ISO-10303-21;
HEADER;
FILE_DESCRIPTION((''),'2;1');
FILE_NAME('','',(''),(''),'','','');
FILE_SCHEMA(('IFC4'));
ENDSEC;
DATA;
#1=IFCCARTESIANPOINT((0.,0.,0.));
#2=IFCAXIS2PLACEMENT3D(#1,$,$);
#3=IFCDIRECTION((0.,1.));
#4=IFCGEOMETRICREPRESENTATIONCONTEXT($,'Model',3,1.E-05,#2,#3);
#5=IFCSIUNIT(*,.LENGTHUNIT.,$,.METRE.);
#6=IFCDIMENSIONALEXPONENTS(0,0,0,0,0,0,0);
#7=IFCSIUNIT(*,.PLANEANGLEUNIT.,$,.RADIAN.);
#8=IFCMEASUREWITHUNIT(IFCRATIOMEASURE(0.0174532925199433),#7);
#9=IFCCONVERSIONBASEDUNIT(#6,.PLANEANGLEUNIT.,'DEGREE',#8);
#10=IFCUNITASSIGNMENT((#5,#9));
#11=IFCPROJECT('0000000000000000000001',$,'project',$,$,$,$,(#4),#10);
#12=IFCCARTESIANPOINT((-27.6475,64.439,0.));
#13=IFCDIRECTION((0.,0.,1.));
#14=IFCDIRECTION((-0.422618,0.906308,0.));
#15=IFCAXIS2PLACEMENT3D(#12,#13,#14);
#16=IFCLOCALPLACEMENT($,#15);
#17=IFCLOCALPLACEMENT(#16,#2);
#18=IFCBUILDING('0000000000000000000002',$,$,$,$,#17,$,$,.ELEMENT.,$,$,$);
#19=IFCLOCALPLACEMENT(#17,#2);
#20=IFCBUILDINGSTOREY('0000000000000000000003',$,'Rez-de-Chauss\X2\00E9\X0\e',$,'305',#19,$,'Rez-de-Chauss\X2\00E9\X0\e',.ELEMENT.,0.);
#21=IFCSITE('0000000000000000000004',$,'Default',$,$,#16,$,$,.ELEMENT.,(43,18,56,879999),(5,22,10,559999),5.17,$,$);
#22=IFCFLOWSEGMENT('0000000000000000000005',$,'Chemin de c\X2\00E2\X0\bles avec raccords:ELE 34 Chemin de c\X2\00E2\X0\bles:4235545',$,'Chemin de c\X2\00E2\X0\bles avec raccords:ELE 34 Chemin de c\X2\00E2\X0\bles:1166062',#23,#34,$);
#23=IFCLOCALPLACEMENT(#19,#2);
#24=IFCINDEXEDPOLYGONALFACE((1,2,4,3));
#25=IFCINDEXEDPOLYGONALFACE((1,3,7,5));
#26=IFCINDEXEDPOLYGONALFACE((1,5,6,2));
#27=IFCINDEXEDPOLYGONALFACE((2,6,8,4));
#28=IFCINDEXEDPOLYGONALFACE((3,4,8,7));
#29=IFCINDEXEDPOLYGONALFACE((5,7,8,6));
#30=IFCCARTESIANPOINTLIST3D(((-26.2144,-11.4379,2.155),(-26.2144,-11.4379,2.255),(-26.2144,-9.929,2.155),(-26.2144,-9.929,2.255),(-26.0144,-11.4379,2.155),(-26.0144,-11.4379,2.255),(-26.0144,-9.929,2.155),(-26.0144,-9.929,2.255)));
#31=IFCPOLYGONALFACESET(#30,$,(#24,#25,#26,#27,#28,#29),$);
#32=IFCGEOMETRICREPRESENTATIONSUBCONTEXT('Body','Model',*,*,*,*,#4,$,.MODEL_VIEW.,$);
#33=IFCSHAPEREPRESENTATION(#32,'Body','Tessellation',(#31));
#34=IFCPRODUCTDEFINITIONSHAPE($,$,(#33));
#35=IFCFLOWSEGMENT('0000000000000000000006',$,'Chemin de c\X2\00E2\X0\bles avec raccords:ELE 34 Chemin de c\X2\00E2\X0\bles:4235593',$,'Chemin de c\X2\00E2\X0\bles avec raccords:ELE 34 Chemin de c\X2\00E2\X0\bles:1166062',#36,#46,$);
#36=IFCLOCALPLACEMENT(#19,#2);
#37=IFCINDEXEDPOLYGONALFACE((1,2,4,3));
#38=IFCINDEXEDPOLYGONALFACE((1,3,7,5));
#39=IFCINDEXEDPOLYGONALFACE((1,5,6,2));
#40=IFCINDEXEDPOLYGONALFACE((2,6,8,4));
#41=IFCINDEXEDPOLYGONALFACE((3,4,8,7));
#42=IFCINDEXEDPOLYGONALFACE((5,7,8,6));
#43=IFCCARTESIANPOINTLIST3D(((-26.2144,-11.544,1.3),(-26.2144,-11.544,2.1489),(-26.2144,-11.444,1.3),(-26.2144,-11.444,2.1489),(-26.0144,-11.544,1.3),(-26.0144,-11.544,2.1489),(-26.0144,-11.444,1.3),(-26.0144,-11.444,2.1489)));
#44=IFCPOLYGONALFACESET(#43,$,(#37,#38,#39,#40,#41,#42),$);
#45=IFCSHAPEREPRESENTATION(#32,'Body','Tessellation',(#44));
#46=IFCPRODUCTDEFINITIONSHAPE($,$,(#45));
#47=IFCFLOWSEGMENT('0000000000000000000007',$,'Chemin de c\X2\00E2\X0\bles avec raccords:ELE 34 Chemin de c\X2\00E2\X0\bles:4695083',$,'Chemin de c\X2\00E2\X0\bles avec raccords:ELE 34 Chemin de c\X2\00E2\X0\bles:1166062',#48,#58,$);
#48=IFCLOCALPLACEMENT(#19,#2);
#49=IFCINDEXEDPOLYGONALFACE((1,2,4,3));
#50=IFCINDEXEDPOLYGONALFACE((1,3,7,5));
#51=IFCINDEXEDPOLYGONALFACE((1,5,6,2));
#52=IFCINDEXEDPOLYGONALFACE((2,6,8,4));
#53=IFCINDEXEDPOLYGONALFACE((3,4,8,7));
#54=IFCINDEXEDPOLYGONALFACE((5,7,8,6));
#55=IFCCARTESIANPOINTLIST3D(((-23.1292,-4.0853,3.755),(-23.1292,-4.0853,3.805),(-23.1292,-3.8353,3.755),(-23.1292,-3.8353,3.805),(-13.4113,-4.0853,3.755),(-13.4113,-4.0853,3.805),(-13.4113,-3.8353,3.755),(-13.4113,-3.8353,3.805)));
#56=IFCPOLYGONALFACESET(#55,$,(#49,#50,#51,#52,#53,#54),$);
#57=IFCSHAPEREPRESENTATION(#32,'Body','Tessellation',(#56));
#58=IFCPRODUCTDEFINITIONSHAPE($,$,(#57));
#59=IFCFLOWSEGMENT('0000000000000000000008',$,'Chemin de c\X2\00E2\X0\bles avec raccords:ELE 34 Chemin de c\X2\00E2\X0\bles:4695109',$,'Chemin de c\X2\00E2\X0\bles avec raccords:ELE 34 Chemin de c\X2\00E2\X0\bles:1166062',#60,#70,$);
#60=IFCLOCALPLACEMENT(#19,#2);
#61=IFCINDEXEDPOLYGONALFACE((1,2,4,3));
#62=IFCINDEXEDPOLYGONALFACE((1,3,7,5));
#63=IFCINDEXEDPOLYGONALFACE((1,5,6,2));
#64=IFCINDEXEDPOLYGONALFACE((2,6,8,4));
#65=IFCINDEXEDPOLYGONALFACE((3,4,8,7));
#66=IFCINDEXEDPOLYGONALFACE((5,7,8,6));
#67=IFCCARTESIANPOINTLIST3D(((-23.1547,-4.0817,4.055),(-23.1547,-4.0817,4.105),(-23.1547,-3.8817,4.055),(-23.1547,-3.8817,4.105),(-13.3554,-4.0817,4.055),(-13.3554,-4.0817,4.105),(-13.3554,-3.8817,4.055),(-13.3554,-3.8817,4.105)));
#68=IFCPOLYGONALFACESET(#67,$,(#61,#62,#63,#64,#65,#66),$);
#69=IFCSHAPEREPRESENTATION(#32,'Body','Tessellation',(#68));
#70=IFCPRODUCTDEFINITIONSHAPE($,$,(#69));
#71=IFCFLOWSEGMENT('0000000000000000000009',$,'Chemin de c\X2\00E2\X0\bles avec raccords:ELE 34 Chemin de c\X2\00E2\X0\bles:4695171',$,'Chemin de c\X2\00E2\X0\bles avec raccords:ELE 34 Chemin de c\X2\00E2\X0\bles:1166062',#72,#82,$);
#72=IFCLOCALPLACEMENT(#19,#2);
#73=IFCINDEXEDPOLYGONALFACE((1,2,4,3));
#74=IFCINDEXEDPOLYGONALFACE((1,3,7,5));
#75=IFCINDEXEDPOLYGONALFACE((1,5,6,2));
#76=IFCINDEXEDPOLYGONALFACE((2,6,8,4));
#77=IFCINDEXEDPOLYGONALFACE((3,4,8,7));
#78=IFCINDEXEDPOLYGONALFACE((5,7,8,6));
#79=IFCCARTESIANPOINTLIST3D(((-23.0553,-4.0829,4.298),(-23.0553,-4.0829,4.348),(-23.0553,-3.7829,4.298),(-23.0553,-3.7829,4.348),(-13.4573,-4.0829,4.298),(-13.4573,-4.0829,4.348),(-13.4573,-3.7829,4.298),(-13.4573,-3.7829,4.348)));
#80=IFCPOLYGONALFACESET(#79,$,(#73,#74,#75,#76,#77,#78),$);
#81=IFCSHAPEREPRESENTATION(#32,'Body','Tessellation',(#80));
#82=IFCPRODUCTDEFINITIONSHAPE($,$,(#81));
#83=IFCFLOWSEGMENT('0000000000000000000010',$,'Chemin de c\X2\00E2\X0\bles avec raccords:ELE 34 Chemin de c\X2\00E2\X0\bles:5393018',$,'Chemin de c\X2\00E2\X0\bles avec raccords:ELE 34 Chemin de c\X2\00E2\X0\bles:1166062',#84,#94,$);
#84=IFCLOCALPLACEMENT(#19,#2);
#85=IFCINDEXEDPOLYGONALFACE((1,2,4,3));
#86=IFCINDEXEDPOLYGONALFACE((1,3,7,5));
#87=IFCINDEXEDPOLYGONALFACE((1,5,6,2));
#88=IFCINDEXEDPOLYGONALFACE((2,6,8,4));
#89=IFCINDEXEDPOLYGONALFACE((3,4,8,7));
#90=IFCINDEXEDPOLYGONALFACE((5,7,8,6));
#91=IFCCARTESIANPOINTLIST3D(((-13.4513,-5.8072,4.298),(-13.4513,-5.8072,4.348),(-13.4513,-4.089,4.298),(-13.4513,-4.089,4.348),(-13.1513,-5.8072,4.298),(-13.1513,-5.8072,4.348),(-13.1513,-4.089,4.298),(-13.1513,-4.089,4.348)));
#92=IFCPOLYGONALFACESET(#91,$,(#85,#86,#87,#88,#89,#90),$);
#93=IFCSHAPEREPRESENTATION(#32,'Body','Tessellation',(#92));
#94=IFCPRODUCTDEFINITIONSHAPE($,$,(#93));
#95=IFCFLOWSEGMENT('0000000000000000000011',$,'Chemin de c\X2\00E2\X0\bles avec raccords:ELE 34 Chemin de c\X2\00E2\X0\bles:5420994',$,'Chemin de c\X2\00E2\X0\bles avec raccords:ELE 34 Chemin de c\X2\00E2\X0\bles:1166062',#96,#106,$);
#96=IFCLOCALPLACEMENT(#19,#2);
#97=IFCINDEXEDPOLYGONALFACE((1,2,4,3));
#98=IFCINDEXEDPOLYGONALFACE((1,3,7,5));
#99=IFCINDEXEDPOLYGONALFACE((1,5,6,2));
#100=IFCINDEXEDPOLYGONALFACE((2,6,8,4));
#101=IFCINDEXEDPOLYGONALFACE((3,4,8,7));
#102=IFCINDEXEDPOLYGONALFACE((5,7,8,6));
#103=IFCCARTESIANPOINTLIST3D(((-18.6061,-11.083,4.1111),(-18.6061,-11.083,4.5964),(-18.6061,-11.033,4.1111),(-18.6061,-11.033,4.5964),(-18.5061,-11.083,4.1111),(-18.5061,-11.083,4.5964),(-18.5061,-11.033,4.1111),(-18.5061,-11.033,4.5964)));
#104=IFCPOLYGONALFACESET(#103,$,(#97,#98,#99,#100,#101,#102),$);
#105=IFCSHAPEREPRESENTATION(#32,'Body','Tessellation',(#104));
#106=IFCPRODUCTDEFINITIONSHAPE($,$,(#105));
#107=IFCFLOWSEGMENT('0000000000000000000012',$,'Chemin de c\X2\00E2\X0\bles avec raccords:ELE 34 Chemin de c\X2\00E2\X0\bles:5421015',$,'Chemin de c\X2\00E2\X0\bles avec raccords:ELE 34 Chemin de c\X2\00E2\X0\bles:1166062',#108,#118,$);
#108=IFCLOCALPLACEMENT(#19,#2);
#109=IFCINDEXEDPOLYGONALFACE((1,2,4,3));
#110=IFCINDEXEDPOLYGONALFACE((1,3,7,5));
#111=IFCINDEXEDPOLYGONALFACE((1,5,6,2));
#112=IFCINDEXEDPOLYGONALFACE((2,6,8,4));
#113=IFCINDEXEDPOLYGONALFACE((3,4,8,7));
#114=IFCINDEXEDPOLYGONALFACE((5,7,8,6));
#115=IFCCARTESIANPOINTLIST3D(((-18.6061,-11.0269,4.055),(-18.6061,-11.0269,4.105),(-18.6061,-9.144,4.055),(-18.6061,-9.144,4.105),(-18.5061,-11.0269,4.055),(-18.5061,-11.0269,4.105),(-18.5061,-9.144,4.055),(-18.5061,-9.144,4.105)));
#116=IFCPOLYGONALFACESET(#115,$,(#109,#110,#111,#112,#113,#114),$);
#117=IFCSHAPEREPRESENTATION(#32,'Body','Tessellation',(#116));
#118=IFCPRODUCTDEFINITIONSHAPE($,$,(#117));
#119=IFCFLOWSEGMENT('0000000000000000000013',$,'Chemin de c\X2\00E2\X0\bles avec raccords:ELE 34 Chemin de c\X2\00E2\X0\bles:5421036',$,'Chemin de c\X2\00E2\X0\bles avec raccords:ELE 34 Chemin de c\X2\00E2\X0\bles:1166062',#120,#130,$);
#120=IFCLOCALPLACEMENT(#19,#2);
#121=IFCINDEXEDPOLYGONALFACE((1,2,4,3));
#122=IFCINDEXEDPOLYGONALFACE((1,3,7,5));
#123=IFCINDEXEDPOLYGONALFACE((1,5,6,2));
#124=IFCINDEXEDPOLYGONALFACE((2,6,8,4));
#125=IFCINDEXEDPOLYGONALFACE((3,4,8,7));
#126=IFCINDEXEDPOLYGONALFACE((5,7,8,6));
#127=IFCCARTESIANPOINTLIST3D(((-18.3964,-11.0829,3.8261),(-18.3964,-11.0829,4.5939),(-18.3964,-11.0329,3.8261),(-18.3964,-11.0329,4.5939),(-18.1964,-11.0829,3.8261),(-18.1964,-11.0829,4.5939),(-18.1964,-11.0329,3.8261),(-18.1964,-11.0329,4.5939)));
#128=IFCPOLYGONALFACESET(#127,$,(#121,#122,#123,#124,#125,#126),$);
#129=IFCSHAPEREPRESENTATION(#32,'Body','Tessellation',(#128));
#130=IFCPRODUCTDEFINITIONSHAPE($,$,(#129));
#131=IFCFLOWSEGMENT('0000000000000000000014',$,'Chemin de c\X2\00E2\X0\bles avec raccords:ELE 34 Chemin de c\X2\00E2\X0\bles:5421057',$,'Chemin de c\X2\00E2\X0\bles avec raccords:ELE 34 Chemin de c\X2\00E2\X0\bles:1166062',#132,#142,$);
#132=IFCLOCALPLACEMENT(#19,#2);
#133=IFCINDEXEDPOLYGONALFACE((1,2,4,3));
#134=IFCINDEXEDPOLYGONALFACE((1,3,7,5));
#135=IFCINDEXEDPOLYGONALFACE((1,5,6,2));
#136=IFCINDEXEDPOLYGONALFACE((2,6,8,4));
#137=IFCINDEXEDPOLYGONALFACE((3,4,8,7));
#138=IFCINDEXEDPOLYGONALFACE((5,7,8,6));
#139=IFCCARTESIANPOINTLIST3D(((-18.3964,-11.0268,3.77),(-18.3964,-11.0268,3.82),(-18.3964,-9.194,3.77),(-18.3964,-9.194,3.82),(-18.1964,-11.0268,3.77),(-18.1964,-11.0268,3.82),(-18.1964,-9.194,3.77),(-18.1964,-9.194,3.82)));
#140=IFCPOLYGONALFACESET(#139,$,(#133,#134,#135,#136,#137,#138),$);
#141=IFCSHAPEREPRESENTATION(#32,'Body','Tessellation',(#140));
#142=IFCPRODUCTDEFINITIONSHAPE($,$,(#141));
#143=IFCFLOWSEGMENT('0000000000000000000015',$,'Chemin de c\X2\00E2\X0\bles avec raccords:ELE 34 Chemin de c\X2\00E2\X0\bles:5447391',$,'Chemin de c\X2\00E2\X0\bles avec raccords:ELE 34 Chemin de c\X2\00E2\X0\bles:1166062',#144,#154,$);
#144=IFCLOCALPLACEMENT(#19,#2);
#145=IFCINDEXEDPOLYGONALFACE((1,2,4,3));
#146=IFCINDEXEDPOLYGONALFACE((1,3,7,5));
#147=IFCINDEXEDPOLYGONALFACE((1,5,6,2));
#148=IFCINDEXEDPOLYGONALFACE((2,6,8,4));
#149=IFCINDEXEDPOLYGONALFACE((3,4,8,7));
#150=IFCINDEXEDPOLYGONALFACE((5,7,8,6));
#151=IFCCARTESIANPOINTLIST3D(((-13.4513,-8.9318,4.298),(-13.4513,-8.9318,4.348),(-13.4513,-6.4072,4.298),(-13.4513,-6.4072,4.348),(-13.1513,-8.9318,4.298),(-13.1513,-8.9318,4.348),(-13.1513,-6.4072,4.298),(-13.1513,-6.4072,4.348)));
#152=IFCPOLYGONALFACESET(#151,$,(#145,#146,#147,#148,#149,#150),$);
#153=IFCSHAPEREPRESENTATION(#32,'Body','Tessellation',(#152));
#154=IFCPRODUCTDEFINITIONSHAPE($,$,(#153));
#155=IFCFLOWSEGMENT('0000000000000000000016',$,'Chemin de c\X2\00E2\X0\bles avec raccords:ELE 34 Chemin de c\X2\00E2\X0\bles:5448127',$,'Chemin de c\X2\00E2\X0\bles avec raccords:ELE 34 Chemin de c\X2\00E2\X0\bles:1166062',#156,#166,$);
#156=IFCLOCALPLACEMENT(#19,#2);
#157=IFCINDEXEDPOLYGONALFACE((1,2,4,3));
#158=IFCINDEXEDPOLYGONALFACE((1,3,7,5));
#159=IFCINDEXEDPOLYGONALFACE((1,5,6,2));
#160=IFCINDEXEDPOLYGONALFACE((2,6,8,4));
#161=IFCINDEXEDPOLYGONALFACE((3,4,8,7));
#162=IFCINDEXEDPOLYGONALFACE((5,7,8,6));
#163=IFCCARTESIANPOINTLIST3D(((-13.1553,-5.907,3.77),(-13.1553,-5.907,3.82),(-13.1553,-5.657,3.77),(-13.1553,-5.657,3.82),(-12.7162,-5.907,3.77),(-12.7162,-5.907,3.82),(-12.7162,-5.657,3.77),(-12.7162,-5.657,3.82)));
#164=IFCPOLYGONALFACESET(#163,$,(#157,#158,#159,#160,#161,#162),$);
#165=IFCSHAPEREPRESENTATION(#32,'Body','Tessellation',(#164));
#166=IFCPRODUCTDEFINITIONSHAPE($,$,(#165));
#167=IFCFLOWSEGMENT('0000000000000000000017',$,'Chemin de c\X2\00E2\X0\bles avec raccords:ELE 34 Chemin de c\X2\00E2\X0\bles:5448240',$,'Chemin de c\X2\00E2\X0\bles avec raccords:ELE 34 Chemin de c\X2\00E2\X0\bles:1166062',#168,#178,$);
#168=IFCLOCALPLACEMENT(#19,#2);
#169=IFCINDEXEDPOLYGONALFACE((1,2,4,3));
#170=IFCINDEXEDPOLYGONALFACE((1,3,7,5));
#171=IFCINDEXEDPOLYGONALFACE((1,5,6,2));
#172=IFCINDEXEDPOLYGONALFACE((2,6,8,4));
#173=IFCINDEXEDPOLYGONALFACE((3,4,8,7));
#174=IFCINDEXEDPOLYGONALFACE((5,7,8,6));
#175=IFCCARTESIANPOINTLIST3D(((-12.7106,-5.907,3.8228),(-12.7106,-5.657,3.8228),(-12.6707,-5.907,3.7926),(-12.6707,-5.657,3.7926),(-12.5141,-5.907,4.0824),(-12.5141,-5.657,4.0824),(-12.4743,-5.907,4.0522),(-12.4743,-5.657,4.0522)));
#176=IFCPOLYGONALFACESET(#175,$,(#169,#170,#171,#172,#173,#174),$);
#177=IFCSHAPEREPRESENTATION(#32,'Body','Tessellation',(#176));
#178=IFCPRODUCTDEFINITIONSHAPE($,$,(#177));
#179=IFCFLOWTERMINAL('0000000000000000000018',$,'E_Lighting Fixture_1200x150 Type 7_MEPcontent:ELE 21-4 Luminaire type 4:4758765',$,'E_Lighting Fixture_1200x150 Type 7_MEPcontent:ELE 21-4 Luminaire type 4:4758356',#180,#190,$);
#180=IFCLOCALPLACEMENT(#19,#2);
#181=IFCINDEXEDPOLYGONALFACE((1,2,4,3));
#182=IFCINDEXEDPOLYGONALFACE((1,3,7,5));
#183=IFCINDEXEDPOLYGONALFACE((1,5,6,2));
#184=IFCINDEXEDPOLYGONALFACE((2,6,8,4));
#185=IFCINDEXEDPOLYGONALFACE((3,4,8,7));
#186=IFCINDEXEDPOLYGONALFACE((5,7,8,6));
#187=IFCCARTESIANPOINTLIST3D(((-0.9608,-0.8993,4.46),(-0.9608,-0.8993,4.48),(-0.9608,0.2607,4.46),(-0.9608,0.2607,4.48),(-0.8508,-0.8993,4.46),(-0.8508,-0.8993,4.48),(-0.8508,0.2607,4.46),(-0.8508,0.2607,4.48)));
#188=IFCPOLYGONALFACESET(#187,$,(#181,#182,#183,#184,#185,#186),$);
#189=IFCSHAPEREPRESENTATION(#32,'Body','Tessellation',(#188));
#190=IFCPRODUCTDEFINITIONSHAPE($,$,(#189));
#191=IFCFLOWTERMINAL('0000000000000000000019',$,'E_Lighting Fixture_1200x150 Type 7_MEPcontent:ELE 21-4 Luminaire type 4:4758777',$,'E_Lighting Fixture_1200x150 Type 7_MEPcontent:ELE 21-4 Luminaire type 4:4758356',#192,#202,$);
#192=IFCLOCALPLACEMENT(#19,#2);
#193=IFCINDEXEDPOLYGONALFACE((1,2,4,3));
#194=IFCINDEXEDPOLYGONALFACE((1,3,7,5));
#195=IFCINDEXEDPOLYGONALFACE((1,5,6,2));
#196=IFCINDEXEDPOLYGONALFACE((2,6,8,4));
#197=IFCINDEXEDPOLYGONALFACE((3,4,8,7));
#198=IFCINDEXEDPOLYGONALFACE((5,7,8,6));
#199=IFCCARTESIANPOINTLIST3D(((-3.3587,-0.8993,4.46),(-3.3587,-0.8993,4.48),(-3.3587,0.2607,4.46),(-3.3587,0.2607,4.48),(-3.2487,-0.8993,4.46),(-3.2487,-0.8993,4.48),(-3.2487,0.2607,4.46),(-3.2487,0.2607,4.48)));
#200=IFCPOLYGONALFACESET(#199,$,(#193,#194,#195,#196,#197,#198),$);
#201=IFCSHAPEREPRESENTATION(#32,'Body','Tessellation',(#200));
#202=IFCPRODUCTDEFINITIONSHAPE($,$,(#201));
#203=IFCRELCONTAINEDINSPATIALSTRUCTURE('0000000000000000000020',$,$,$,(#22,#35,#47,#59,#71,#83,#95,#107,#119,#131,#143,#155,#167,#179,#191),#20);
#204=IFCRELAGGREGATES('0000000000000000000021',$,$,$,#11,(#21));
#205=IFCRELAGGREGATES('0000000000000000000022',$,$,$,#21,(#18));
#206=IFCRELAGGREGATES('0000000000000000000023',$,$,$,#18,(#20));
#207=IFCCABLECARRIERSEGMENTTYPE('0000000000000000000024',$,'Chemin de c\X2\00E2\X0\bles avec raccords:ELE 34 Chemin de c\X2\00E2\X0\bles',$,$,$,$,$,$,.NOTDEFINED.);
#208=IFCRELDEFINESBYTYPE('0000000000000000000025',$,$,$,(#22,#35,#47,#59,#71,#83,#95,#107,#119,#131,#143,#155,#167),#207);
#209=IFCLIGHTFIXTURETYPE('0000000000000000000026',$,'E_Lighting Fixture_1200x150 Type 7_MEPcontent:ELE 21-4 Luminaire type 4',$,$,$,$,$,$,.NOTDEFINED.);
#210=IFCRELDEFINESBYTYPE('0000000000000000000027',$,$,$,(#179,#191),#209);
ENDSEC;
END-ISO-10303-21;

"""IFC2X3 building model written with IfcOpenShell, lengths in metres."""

from ifc_helpers import new_model, entity, si_unit, converted_unit, direction, frame, frame_2d, origin, origin_2d_with_axis, place, context, subcontext, project, spatial, rectangle, extrude, source, transform, mapped, type_object, type_shapes, element, save


model = new_model("IFC2X3")

# Units and contexts
model_context = context("Model", 3, precision=1e-05, world=origin(), true_north=direction((0.0, 1.0)))
body_context = subcontext(model_context, "Body", "Model", "MODEL_VIEW")
ifc_project = project(units=[si_unit("LENGTHUNIT", "METRE"), converted_unit("PLANEANGLEUNIT", "DEGREE", entity("IfcRatioMeasure", 0.0174532925199433), si_unit("PLANEANGLEUNIT", "RADIAN"), dimensions=[0, 0, 0, 0, 0, 0, 0])], contexts=[model_context])

# Site, building, storey
site_placement = place(None, frame((-27.6475, 64.439, 0.0), z_axis=(0.0, 0.0, 1.0), x_axis=(-0.422618, 0.906308, 0.0)))
site = spatial("IfcSite", under=ifc_project, at=site_placement, Name="Default", CompositionType="ELEMENT", RefLatitude=(43, 18, 56, 879999), RefLongitude=(5, 22, 10, 559999), RefElevation=5.17)
building_placement = place(site_placement, origin())
building = spatial("IfcBuilding", under=site, at=building_placement, CompositionType="ELEMENT")
storey_placement = place(building_placement, origin())
storey = spatial("IfcBuildingStorey", under=building, at=storey_placement, Name="Rez-de-Chaussée", ObjectType="305", LongName="Rez-de-Chaussée", CompositionType="ELEMENT", Elevation=0.0)

# Flow segments
cable_carrier_segment_type = type_object("IfcCableCarrierSegmentType", Name="Chemin de câbles avec raccords:ELE 34 Chemin de câbles", PredefinedType="NOTDEFINED")
flow_segment_1_placement = place(storey_placement, origin())
element("IfcFlowSegment", 1, at=flow_segment_1_placement, inside=storey, type_object=cable_carrier_segment_type, Name="Chemin de câbles avec raccords:ELE 34 Chemin de câbles:4235545", ObjectType="Chemin de câbles avec raccords:ELE 34 Chemin de câbles:1166062", context=body_context, shape_type="SweptSolid", body=[
    extrude(rectangle(XDim=1.509, YDim=0.2, at=frame_2d((0.0, 0.0), x_axis=(1.0, 0.0))), frame((-26.1144, -10.6835, 2.155), z_axis=(0.0, 0.0, 1.0), x_axis=(0.0, -1.0, 0.0)), (0.0, 0.0, 1.0), 0.1),
])
flow_segment_2_placement = place(storey_placement, origin())
element("IfcFlowSegment", 2, at=flow_segment_2_placement, inside=storey, type_object=cable_carrier_segment_type, Name="Chemin de câbles avec raccords:ELE 34 Chemin de câbles:4235593", ObjectType="Chemin de câbles avec raccords:ELE 34 Chemin de câbles:1166062", context=body_context, shape_type="SweptSolid", body=[
    extrude(rectangle(XDim=0.1, YDim=0.2, at=frame_2d((0.0, 0.0), x_axis=(1.0, 0.0))), frame((-26.1144, -11.494, 1.3), z_axis=(0.0, 0.0, 1.0), x_axis=(0.0, -1.0, 0.0)), (0.0, 0.0, 1.0), 0.8489),
])
flow_segment_3_placement = place(storey_placement, origin())
element("IfcFlowSegment", 3, at=flow_segment_3_placement, inside=storey, type_object=cable_carrier_segment_type, Name="Chemin de câbles avec raccords:ELE 34 Chemin de câbles:4695083", ObjectType="Chemin de câbles avec raccords:ELE 34 Chemin de câbles:1166062", context=body_context, shape_type="SweptSolid", body=[
    extrude(rectangle(XDim=9.7178, YDim=0.25, at=frame_2d((0.0, 0.0), x_axis=(1.0, 0.0))), frame((-18.2703, -3.9603, 3.755), z_axis=(0.0, 0.0, 1.0), x_axis=(-1.0, 0.0, 0.0)), (0.0, 0.0, 1.0), 0.05),
])
flow_segment_4_placement = place(storey_placement, origin())
element("IfcFlowSegment", 4, at=flow_segment_4_placement, inside=storey, type_object=cable_carrier_segment_type, Name="Chemin de câbles avec raccords:ELE 34 Chemin de câbles:4695109", ObjectType="Chemin de câbles avec raccords:ELE 34 Chemin de câbles:1166062", context=body_context, shape_type="SweptSolid", body=[
    extrude(rectangle(XDim=9.7993, YDim=0.2, at=frame_2d((0.0, 0.0), x_axis=(1.0, 0.0))), frame((-18.255, -3.9817, 4.055), z_axis=(0.0, 0.0, 1.0), x_axis=(-1.0, 0.0, 0.0)), (0.0, 0.0, 1.0), 0.05),
])
flow_segment_5_placement = place(storey_placement, origin())
element("IfcFlowSegment", 5, at=flow_segment_5_placement, inside=storey, type_object=cable_carrier_segment_type, Name="Chemin de câbles avec raccords:ELE 34 Chemin de câbles:4695171", ObjectType="Chemin de câbles avec raccords:ELE 34 Chemin de câbles:1166062", context=body_context, shape_type="SweptSolid", body=[
    extrude(rectangle(XDim=9.5979, YDim=0.3, at=frame_2d((0.0, 0.0), x_axis=(1.0, 0.0))), frame((-18.2563, -3.9329, 4.298)), (0.0, 0.0, 1.0), 0.05),
])
flow_segment_6_placement = place(storey_placement, origin())
element("IfcFlowSegment", 6, at=flow_segment_6_placement, inside=storey, type_object=cable_carrier_segment_type, Name="Chemin de câbles avec raccords:ELE 34 Chemin de câbles:5393018", ObjectType="Chemin de câbles avec raccords:ELE 34 Chemin de câbles:1166062", context=body_context, shape_type="SweptSolid", body=[
    extrude(rectangle(XDim=1.7182, YDim=0.3, at=frame_2d((0.0, 0.0), x_axis=(1.0, 0.0))), frame((-13.3013, -4.9481, 4.298), z_axis=(0.0, 0.0, 1.0), x_axis=(0.0, 1.0, 0.0)), (0.0, 0.0, 1.0), 0.05),
])
flow_segment_7_placement = place(storey_placement, origin())
element("IfcFlowSegment", 7, at=flow_segment_7_placement, inside=storey, type_object=cable_carrier_segment_type, Name="Chemin de câbles avec raccords:ELE 34 Chemin de câbles:5420994", ObjectType="Chemin de câbles avec raccords:ELE 34 Chemin de câbles:1166062", context=body_context, shape_type="SweptSolid", body=[
    extrude(rectangle(XDim=0.05, YDim=0.1, at=origin_2d_with_axis()), frame((-18.5561, -11.058, 4.1111), z_axis=(0.0, 0.0, 1.0), x_axis=(0.0, 1.0, 0.0)), (0.0, 0.0, 1.0), 0.4853),
])
flow_segment_8_placement = place(storey_placement, origin())
element("IfcFlowSegment", 8, at=flow_segment_8_placement, inside=storey, type_object=cable_carrier_segment_type, Name="Chemin de câbles avec raccords:ELE 34 Chemin de câbles:5421015", ObjectType="Chemin de câbles avec raccords:ELE 34 Chemin de câbles:1166062", context=body_context, shape_type="SweptSolid", body=[
    extrude(rectangle(XDim=1.8829, YDim=0.1, at=frame_2d((0.0, 0.0), x_axis=(1.0, 0.0))), frame((-18.5561, -10.0854, 4.055), z_axis=(0.0, 0.0, 1.0), x_axis=(0.0, -1.0, 0.0)), (0.0, 0.0, 1.0), 0.05),
])
flow_segment_9_placement = place(storey_placement, origin())
element("IfcFlowSegment", 9, at=flow_segment_9_placement, inside=storey, type_object=cable_carrier_segment_type, Name="Chemin de câbles avec raccords:ELE 34 Chemin de câbles:5421036", ObjectType="Chemin de câbles avec raccords:ELE 34 Chemin de câbles:1166062", context=body_context, shape_type="SweptSolid", body=[
    extrude(rectangle(XDim=0.05, YDim=0.2, at=origin_2d_with_axis()), frame((-18.2964, -11.0579, 3.8261), z_axis=(0.0, 0.0, 1.0), x_axis=(0.0, 1.0, 0.0)), (0.0, 0.0, 1.0), 0.7678),
])
flow_segment_10_placement = place(storey_placement, origin())
element("IfcFlowSegment", 10, at=flow_segment_10_placement, inside=storey, type_object=cable_carrier_segment_type, Name="Chemin de câbles avec raccords:ELE 34 Chemin de câbles:5421057", ObjectType="Chemin de câbles avec raccords:ELE 34 Chemin de câbles:1166062", context=body_context, shape_type="SweptSolid", body=[
    extrude(rectangle(XDim=1.8328, YDim=0.2, at=origin_2d_with_axis()), frame((-18.2964, -10.1104, 3.77), z_axis=(0.0, 0.0, 1.0), x_axis=(0.0, -1.0, 0.0)), (0.0, 0.0, 1.0), 0.05),
])
flow_segment_11_placement = place(storey_placement, origin())
element("IfcFlowSegment", 11, at=flow_segment_11_placement, inside=storey, type_object=cable_carrier_segment_type, Name="Chemin de câbles avec raccords:ELE 34 Chemin de câbles:5447391", ObjectType="Chemin de câbles avec raccords:ELE 34 Chemin de câbles:1166062", context=body_context, shape_type="SweptSolid", body=[
    extrude(rectangle(XDim=2.5247, YDim=0.3, at=frame_2d((0.0, 0.0), x_axis=(1.0, 0.0))), frame((-13.3013, -7.6695, 4.298), z_axis=(0.0, 0.0, 1.0), x_axis=(0.0, 1.0, 0.0)), (0.0, 0.0, 1.0), 0.05),
])
flow_segment_12_placement = place(storey_placement, origin())
element("IfcFlowSegment", 12, at=flow_segment_12_placement, inside=storey, type_object=cable_carrier_segment_type, Name="Chemin de câbles avec raccords:ELE 34 Chemin de câbles:5448127", ObjectType="Chemin de câbles avec raccords:ELE 34 Chemin de câbles:1166062", context=body_context, shape_type="SweptSolid", body=[
    extrude(rectangle(XDim=0.25, YDim=0.439, at=frame_2d((0.0, 0.0), x_axis=(1.0, 0.0))), frame((-12.9357, -5.782, 3.77), z_axis=(0.0, 0.0, 1.0), x_axis=(0.0, -1.0, 0.0)), (0.0, 0.0, 1.0), 0.05),
])
flow_segment_13_placement = place(storey_placement, origin())
element("IfcFlowSegment", 13, at=flow_segment_13_placement, inside=storey, type_object=cable_carrier_segment_type, Name="Chemin de câbles avec raccords:ELE 34 Chemin de câbles:5448240", ObjectType="Chemin de câbles avec raccords:ELE 34 Chemin de câbles:1166062", context=body_context, shape_type="SweptSolid", body=[
    extrude(rectangle(XDim=0.05, YDim=0.25, at=frame_2d((0.0, 0.0), x_axis=(0.0, 1.0))), frame((-12.6906, -5.782, 3.8077), z_axis=(0.603454, 0.0, 0.797398), x_axis=(0.0, 1.0, 0.0)), (0.0, 0.0, 1.0), 0.3255),
])

# Flow terminals
light_fixture_type_1 = type_object("IfcLightFixtureType", Name="E_Lighting Fixture_1200x150 Type 7_MEPcontent:ELE 21-4 Luminaire type 4", PredefinedType="NOTDEFINED")
shared_shape_1 = source(origin(), body_context, "Body", "SweptSolid", [
    extrude(rectangle(XDim=0.11, YDim=1.16, at=origin_2d_with_axis()), frame((0.0, 0.0, 0.0), z_axis=(0.0, 0.0, 1.0), x_axis=(0.0, -1.0, 0.0)), (0.0, 0.0, 1.0), 0.02),
])
type_shapes(light_fixture_type_1, [shared_shape_1])
for number, where, z_axis, x_axis, name in (
    (14, (-0.9058, -0.3193, 4.46), (0.0, 0.0, 1.0), (0.0, -1.0, 0.0), "E_Lighting Fixture_1200x150 Type 7_MEPcontent:ELE 21-4 Luminaire type 4:4758765"),
    (15, (-3.3037, -0.3193, 4.46), (0.0, 0.0, 1.0), (0.0, -1.0, 0.0), "E_Lighting Fixture_1200x150 Type 7_MEPcontent:ELE 21-4 Luminaire type 4:4758777"),
):
    element("IfcFlowTerminal", number, at=place(storey_placement, frame(where, z_axis=z_axis, x_axis=x_axis)), inside=storey, type_object=light_fixture_type_1, Name=name, ObjectType="E_Lighting Fixture_1200x150 Type 7_MEPcontent:ELE 21-4 Luminaire type 4:4758356", context=body_context, shape_type="MappedRepresentation", body=[
        mapped(shared_shape_1, transform((0.0, 0.0, 0.0), scale=1.0)),
    ])

save(model, "model.ifc")
